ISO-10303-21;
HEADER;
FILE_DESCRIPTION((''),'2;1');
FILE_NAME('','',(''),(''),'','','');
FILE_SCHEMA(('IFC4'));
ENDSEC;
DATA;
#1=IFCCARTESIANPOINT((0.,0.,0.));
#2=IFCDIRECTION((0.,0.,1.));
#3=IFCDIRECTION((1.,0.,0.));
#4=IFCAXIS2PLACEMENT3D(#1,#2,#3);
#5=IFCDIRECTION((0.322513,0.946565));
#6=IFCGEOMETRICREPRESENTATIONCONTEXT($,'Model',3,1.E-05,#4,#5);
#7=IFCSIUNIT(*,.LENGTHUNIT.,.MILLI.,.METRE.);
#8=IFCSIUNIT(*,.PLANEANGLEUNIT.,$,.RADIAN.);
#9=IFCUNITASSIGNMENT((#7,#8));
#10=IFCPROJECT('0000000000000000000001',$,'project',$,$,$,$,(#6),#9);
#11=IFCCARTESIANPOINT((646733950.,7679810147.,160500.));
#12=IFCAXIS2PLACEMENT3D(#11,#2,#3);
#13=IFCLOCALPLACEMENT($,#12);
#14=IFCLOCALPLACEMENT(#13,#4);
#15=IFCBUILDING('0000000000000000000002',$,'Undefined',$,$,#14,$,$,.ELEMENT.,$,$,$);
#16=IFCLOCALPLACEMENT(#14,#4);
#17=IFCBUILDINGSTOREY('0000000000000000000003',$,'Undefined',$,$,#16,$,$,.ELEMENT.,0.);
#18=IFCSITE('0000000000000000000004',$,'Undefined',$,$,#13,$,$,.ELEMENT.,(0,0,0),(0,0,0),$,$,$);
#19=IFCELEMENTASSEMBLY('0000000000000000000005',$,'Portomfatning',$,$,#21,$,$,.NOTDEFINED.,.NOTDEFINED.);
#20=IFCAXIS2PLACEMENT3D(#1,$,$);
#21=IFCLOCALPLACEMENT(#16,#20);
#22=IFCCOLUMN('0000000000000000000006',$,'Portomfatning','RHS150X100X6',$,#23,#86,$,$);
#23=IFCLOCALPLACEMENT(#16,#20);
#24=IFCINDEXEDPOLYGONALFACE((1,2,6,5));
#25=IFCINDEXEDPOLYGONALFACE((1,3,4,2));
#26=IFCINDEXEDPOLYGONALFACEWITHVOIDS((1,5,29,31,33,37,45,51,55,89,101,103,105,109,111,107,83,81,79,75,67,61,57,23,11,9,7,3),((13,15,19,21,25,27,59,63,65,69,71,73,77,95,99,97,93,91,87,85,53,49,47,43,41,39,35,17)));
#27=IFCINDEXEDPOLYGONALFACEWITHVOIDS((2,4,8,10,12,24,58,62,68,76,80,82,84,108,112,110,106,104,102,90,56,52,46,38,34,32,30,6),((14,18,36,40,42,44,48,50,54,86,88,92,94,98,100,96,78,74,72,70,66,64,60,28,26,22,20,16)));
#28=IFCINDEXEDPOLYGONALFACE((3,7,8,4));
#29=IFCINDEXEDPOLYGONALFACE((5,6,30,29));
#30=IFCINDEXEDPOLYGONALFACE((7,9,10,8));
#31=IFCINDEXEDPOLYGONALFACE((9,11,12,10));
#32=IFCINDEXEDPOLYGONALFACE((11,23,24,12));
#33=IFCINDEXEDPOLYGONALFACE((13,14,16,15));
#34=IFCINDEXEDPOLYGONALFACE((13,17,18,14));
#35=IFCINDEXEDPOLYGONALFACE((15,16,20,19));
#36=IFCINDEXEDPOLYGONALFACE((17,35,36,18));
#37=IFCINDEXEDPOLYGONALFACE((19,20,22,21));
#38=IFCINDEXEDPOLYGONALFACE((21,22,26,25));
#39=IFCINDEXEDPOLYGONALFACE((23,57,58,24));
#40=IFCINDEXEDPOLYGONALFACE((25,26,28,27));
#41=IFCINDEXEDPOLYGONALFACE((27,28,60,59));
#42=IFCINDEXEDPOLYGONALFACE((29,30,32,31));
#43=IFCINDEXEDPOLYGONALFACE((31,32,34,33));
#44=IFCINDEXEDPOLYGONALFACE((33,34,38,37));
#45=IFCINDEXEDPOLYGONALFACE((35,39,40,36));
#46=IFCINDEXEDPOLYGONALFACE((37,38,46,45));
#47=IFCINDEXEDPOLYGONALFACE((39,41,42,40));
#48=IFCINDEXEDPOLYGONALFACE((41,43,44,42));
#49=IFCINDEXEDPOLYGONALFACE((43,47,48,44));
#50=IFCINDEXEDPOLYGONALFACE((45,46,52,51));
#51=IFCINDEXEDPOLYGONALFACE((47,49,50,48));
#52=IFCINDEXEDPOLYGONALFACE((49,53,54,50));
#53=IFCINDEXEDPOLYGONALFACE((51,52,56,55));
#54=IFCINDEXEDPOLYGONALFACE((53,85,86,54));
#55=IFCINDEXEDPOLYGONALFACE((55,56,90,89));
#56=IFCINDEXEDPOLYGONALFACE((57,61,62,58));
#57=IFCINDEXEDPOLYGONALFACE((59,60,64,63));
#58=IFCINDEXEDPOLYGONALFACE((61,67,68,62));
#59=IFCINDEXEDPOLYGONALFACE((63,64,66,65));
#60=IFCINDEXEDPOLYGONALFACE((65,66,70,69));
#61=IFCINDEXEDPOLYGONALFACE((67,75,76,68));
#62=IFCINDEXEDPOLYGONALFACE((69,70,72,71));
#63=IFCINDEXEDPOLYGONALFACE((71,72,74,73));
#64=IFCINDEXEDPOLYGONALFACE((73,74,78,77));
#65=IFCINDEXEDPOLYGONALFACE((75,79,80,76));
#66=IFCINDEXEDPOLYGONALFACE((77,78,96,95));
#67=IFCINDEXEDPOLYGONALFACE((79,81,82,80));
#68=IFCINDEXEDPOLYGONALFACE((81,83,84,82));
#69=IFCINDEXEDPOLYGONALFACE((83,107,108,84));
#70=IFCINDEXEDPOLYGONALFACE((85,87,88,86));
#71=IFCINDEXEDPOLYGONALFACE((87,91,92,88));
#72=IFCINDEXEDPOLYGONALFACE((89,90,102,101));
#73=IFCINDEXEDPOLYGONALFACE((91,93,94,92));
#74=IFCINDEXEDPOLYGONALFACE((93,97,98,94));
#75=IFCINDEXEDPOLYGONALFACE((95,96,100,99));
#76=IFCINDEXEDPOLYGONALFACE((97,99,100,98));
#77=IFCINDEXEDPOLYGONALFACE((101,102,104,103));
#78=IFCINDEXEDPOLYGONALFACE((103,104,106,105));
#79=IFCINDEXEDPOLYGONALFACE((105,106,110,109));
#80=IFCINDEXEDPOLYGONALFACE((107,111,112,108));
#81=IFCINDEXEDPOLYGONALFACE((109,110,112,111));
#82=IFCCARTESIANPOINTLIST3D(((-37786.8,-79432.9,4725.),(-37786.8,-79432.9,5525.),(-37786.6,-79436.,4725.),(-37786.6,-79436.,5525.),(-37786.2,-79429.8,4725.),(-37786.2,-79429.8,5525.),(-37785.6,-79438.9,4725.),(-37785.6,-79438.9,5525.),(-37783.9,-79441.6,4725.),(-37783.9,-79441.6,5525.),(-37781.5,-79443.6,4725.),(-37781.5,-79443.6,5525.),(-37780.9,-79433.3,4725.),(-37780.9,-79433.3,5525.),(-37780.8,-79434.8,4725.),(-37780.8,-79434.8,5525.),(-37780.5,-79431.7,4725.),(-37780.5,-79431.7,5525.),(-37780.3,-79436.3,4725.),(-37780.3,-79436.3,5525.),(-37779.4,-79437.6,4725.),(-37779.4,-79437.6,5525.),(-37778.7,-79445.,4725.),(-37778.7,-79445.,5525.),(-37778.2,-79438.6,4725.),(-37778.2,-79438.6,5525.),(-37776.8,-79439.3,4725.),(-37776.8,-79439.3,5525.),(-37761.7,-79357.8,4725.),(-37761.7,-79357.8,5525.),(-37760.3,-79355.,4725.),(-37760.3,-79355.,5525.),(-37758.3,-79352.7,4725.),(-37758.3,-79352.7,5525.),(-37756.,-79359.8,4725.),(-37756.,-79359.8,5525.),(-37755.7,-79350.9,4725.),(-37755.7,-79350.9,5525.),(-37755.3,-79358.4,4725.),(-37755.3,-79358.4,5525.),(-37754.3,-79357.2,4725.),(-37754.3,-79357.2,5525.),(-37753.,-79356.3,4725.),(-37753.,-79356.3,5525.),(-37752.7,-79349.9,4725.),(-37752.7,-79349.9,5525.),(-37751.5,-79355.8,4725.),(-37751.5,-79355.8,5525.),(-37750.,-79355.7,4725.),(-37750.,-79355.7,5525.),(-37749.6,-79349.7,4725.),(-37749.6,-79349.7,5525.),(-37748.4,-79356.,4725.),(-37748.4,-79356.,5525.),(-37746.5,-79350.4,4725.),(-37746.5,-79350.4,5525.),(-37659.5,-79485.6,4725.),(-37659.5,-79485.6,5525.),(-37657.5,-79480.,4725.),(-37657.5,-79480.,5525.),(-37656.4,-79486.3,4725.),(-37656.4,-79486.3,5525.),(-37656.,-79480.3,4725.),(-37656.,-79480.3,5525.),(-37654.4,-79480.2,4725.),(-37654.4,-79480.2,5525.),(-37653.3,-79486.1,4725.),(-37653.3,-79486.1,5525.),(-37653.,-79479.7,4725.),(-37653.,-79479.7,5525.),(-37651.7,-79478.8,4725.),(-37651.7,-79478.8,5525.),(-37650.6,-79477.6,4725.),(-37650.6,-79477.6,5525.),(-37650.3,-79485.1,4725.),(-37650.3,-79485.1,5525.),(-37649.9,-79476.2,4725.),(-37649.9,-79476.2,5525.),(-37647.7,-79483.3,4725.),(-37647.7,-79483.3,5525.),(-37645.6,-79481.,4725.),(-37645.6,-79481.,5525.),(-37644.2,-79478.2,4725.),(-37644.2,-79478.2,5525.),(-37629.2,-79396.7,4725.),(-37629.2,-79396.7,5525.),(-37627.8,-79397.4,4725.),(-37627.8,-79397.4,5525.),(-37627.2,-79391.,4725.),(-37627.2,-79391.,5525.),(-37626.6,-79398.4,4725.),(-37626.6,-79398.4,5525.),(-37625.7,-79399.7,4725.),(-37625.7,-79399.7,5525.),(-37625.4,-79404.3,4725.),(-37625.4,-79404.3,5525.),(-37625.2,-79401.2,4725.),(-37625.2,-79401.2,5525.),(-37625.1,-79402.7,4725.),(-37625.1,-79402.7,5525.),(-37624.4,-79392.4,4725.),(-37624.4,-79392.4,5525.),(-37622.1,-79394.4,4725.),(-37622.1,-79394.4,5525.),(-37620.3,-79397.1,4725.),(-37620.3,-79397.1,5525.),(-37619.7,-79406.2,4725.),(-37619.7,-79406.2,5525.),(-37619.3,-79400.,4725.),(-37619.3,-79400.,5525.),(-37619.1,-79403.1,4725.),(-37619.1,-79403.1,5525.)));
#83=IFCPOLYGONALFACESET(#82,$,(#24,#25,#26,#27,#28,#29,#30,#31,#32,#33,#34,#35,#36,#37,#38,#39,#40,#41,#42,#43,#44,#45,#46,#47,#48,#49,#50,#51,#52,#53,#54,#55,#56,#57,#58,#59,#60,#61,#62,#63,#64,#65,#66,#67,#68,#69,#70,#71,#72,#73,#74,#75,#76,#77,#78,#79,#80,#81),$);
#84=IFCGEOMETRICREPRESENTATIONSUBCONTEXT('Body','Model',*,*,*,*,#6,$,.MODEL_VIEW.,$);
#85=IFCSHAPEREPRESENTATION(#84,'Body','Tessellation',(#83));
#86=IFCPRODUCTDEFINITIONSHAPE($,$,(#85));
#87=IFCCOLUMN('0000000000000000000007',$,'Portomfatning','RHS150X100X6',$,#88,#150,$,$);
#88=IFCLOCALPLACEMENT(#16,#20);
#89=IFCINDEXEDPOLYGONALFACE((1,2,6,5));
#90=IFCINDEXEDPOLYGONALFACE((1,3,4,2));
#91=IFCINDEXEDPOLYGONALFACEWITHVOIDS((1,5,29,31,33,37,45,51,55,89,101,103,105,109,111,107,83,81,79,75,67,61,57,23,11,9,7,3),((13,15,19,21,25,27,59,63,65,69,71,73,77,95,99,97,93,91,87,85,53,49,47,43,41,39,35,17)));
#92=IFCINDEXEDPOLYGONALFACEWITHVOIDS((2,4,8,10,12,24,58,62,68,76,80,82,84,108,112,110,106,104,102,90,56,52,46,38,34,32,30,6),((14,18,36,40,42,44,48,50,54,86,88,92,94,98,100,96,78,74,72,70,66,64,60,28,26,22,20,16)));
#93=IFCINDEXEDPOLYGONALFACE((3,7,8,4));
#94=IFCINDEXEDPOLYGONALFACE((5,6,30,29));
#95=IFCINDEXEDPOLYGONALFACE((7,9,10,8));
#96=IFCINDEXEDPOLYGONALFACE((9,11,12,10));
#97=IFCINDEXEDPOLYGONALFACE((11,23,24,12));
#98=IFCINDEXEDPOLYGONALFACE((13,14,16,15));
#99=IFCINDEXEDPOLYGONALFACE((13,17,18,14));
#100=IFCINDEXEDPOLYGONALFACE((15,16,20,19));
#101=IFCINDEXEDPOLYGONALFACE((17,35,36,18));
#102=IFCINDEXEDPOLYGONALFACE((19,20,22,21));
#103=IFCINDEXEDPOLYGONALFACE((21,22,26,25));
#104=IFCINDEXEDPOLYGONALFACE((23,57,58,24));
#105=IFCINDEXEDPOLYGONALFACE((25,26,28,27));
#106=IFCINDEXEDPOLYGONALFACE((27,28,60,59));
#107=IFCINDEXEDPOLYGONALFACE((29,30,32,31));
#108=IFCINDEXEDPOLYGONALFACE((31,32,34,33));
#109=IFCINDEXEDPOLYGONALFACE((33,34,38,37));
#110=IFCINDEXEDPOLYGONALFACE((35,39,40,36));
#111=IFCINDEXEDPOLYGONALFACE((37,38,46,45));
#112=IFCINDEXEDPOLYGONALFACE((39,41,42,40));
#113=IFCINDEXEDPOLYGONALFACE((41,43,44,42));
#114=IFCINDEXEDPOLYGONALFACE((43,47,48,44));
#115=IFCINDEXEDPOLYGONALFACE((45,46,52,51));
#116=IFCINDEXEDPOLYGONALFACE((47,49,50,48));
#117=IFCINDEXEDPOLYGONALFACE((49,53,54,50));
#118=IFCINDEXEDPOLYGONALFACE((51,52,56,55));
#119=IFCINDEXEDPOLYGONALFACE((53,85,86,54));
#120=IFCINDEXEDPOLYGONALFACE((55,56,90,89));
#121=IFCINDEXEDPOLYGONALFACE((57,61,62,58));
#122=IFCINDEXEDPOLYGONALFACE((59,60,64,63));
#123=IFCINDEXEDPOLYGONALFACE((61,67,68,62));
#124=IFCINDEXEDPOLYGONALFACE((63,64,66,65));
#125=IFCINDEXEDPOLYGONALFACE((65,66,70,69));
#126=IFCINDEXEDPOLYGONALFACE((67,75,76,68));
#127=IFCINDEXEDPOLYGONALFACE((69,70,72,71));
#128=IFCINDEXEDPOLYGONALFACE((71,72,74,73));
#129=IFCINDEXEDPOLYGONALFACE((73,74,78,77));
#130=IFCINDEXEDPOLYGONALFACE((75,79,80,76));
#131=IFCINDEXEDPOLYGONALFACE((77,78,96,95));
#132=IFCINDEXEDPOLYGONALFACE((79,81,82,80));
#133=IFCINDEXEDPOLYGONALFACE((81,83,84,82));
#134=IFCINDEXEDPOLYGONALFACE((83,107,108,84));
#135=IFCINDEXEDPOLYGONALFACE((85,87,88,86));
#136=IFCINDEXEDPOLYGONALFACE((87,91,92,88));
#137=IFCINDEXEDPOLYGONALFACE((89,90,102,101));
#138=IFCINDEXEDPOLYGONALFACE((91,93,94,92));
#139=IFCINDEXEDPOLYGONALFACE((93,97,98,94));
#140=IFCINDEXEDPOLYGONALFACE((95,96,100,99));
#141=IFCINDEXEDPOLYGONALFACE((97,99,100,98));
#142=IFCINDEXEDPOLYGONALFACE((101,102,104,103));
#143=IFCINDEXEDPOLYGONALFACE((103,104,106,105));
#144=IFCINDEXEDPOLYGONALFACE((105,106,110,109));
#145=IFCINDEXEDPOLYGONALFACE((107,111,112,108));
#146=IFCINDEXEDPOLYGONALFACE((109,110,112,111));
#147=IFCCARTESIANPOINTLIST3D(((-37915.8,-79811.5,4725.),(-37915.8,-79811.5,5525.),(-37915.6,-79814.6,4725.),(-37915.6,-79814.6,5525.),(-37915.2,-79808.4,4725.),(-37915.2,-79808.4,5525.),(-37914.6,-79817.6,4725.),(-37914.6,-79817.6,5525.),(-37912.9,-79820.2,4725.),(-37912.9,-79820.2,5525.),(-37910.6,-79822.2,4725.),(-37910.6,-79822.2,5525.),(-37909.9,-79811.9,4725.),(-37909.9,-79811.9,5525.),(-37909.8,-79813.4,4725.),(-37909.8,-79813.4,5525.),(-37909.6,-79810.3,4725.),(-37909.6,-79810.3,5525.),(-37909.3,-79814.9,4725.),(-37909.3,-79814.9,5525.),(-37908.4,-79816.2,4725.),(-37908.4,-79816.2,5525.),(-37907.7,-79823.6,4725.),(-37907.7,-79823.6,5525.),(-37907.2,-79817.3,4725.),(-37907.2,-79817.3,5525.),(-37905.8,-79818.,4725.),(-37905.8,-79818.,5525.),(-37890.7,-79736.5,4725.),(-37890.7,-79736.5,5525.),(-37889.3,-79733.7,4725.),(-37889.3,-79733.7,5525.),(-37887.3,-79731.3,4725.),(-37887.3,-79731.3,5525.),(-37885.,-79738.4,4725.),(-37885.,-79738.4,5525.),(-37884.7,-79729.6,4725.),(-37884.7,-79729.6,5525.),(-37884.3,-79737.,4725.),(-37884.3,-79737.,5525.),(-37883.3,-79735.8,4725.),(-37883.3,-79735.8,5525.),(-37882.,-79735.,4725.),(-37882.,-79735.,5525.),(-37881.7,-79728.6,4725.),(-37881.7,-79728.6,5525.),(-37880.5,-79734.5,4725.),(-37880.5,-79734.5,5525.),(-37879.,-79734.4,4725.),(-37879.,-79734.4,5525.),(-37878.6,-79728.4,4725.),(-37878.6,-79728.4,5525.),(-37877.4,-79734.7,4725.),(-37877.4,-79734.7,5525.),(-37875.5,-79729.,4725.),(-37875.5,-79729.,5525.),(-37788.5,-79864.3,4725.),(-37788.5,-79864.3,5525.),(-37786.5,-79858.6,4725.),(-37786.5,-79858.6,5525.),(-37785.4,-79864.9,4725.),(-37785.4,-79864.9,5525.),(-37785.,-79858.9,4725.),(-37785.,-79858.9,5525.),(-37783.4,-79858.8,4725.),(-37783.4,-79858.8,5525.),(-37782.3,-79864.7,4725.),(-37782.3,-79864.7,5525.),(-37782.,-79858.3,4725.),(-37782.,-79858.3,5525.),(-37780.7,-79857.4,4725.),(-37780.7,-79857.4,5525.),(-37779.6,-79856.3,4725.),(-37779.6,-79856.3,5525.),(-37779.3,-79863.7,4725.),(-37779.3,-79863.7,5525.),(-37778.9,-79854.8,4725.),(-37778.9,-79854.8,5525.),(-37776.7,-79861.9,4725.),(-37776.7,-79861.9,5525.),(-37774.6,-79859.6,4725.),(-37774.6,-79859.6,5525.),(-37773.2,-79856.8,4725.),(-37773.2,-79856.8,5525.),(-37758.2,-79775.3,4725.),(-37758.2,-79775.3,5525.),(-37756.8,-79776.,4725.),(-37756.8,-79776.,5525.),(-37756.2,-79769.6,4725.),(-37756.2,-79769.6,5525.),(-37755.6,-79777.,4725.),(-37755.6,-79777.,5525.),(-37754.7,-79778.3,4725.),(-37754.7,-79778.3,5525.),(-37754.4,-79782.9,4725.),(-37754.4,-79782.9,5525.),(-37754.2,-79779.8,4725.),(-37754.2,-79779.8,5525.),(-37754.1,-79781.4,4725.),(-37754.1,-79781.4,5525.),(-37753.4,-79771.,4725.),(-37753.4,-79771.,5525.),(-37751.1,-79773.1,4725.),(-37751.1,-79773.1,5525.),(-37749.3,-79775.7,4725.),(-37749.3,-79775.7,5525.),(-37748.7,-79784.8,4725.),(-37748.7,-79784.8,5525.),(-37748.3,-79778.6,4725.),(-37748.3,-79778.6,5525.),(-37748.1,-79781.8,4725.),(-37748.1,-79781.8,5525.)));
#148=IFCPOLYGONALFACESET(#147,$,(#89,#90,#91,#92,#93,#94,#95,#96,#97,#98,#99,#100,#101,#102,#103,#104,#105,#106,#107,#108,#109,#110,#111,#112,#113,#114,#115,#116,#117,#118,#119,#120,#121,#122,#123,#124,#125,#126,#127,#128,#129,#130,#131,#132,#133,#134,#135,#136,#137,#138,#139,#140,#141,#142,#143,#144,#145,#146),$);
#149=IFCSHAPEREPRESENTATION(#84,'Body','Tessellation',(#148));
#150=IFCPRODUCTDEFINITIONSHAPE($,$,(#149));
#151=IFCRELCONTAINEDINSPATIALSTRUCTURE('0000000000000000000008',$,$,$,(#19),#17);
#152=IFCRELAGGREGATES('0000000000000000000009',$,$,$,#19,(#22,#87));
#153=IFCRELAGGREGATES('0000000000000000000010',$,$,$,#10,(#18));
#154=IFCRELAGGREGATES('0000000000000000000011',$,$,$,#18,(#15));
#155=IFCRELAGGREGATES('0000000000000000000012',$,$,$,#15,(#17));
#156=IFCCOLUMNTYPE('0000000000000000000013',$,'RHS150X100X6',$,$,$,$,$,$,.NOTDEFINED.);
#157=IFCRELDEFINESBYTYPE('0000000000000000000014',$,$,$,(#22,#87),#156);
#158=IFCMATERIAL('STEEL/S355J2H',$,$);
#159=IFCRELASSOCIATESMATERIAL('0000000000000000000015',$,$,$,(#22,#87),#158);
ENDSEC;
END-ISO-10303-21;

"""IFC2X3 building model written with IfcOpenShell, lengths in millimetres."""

from ifc_helpers import new_model, si_unit, direction, frame, origin_with_axes, origin_2d_with_axis, place, context, subcontext, project, spatial, hollow_rectangle, extrude, material, type_object, element, aggregate, save


model = new_model("IFC2X3")

# Units and contexts
model_context = context("Model", 3, precision=1e-05, world=origin_with_axes(), true_north=direction((0.322513, 0.946565)))
body_context = subcontext(model_context, "Body", "Model", "MODEL_VIEW")
ifc_project = project(units=[si_unit("LENGTHUNIT", "METRE", prefix="MILLI"), si_unit("PLANEANGLEUNIT", "RADIAN")], contexts=[model_context])

# Site, building, storey
site_placement = place(None, frame((646733950.0, 7679810147.0, 160500.0), z_axis=(0.0, 0.0, 1.0), x_axis=(1.0, 0.0, 0.0)))
site = spatial("IfcSite", under=ifc_project, at=site_placement, Name="Undefined", CompositionType="ELEMENT", RefLatitude=(0, 0, 0), RefLongitude=(0, 0, 0))
building_placement = place(site_placement, origin_with_axes())
building = spatial("IfcBuilding", under=site, at=building_placement, Name="Undefined", CompositionType="ELEMENT")
storey_placement = place(building_placement, origin_with_axes())
storey = spatial("IfcBuildingStorey", under=building, at=storey_placement, Name="Undefined", CompositionType="ELEMENT", Elevation=0.0)

# Element assembly, columns
assembly_1_placement = place(storey_placement, origin_with_axes())
assembly_1 = element("IfcElementAssembly", 1, at=assembly_1_placement, inside=storey, Name="Portomfatning", AssemblyPlace="NOTDEFINED", PredefinedType="NOTDEFINED")
ifc_material_1 = material(Name="STEEL/S355J2H")
column_type_1 = type_object("IfcColumnType", Name="RHS150X100X6", PredefinedType="NOTDEFINED")
column_1_placement = place(assembly_1_placement, frame((-37703.0, -79418.0, 4725.0), z_axis=(0.0, 0.0, 1.0), x_axis=(0.946565, -0.322513, 0.0)))
column_1 = element("IfcColumn", 2, at=column_1_placement, type_object=column_type_1, material=ifc_material_1, Name="Portomfatning", Description="RHS150X100X6", context=body_context, shape_type="SweptSolid", body=[
    extrude(hollow_rectangle(XDim=100.0, YDim=150.0, WallThickness=6.0, InnerFilletRadius=6.0, OuterFilletRadius=12.0, at=origin_2d_with_axis()), frame((0.0, 0.0, 800.0), z_axis=(0.0, 0.0, -1.0), x_axis=(0.0, 1.0, 0.0)), (0.0, 0.0, 1.0), 800.0),
])
column_2_placement = place(assembly_1_placement, frame((-37832.0, -79796.6, 4725.0), z_axis=(0.0, 0.0, 1.0), x_axis=(0.946565, -0.322513, 0.0)))
column_2 = element("IfcColumn", 3, at=column_2_placement, type_object=column_type_1, material=ifc_material_1, Name="Portomfatning", Description="RHS150X100X6", context=body_context, shape_type="SweptSolid", body=[
    extrude(hollow_rectangle(XDim=100.0, YDim=150.0, WallThickness=6.0, InnerFilletRadius=6.0, OuterFilletRadius=12.0, at=origin_2d_with_axis()), frame((0.0, 0.0, 800.0), z_axis=(0.0, 0.0, -1.0), x_axis=(0.0, 1.0, 0.0)), (0.0, 0.0, 1.0), 800.0),
])

aggregate(assembly_1, [column_1, column_2])

save(model, "model.ifc")
